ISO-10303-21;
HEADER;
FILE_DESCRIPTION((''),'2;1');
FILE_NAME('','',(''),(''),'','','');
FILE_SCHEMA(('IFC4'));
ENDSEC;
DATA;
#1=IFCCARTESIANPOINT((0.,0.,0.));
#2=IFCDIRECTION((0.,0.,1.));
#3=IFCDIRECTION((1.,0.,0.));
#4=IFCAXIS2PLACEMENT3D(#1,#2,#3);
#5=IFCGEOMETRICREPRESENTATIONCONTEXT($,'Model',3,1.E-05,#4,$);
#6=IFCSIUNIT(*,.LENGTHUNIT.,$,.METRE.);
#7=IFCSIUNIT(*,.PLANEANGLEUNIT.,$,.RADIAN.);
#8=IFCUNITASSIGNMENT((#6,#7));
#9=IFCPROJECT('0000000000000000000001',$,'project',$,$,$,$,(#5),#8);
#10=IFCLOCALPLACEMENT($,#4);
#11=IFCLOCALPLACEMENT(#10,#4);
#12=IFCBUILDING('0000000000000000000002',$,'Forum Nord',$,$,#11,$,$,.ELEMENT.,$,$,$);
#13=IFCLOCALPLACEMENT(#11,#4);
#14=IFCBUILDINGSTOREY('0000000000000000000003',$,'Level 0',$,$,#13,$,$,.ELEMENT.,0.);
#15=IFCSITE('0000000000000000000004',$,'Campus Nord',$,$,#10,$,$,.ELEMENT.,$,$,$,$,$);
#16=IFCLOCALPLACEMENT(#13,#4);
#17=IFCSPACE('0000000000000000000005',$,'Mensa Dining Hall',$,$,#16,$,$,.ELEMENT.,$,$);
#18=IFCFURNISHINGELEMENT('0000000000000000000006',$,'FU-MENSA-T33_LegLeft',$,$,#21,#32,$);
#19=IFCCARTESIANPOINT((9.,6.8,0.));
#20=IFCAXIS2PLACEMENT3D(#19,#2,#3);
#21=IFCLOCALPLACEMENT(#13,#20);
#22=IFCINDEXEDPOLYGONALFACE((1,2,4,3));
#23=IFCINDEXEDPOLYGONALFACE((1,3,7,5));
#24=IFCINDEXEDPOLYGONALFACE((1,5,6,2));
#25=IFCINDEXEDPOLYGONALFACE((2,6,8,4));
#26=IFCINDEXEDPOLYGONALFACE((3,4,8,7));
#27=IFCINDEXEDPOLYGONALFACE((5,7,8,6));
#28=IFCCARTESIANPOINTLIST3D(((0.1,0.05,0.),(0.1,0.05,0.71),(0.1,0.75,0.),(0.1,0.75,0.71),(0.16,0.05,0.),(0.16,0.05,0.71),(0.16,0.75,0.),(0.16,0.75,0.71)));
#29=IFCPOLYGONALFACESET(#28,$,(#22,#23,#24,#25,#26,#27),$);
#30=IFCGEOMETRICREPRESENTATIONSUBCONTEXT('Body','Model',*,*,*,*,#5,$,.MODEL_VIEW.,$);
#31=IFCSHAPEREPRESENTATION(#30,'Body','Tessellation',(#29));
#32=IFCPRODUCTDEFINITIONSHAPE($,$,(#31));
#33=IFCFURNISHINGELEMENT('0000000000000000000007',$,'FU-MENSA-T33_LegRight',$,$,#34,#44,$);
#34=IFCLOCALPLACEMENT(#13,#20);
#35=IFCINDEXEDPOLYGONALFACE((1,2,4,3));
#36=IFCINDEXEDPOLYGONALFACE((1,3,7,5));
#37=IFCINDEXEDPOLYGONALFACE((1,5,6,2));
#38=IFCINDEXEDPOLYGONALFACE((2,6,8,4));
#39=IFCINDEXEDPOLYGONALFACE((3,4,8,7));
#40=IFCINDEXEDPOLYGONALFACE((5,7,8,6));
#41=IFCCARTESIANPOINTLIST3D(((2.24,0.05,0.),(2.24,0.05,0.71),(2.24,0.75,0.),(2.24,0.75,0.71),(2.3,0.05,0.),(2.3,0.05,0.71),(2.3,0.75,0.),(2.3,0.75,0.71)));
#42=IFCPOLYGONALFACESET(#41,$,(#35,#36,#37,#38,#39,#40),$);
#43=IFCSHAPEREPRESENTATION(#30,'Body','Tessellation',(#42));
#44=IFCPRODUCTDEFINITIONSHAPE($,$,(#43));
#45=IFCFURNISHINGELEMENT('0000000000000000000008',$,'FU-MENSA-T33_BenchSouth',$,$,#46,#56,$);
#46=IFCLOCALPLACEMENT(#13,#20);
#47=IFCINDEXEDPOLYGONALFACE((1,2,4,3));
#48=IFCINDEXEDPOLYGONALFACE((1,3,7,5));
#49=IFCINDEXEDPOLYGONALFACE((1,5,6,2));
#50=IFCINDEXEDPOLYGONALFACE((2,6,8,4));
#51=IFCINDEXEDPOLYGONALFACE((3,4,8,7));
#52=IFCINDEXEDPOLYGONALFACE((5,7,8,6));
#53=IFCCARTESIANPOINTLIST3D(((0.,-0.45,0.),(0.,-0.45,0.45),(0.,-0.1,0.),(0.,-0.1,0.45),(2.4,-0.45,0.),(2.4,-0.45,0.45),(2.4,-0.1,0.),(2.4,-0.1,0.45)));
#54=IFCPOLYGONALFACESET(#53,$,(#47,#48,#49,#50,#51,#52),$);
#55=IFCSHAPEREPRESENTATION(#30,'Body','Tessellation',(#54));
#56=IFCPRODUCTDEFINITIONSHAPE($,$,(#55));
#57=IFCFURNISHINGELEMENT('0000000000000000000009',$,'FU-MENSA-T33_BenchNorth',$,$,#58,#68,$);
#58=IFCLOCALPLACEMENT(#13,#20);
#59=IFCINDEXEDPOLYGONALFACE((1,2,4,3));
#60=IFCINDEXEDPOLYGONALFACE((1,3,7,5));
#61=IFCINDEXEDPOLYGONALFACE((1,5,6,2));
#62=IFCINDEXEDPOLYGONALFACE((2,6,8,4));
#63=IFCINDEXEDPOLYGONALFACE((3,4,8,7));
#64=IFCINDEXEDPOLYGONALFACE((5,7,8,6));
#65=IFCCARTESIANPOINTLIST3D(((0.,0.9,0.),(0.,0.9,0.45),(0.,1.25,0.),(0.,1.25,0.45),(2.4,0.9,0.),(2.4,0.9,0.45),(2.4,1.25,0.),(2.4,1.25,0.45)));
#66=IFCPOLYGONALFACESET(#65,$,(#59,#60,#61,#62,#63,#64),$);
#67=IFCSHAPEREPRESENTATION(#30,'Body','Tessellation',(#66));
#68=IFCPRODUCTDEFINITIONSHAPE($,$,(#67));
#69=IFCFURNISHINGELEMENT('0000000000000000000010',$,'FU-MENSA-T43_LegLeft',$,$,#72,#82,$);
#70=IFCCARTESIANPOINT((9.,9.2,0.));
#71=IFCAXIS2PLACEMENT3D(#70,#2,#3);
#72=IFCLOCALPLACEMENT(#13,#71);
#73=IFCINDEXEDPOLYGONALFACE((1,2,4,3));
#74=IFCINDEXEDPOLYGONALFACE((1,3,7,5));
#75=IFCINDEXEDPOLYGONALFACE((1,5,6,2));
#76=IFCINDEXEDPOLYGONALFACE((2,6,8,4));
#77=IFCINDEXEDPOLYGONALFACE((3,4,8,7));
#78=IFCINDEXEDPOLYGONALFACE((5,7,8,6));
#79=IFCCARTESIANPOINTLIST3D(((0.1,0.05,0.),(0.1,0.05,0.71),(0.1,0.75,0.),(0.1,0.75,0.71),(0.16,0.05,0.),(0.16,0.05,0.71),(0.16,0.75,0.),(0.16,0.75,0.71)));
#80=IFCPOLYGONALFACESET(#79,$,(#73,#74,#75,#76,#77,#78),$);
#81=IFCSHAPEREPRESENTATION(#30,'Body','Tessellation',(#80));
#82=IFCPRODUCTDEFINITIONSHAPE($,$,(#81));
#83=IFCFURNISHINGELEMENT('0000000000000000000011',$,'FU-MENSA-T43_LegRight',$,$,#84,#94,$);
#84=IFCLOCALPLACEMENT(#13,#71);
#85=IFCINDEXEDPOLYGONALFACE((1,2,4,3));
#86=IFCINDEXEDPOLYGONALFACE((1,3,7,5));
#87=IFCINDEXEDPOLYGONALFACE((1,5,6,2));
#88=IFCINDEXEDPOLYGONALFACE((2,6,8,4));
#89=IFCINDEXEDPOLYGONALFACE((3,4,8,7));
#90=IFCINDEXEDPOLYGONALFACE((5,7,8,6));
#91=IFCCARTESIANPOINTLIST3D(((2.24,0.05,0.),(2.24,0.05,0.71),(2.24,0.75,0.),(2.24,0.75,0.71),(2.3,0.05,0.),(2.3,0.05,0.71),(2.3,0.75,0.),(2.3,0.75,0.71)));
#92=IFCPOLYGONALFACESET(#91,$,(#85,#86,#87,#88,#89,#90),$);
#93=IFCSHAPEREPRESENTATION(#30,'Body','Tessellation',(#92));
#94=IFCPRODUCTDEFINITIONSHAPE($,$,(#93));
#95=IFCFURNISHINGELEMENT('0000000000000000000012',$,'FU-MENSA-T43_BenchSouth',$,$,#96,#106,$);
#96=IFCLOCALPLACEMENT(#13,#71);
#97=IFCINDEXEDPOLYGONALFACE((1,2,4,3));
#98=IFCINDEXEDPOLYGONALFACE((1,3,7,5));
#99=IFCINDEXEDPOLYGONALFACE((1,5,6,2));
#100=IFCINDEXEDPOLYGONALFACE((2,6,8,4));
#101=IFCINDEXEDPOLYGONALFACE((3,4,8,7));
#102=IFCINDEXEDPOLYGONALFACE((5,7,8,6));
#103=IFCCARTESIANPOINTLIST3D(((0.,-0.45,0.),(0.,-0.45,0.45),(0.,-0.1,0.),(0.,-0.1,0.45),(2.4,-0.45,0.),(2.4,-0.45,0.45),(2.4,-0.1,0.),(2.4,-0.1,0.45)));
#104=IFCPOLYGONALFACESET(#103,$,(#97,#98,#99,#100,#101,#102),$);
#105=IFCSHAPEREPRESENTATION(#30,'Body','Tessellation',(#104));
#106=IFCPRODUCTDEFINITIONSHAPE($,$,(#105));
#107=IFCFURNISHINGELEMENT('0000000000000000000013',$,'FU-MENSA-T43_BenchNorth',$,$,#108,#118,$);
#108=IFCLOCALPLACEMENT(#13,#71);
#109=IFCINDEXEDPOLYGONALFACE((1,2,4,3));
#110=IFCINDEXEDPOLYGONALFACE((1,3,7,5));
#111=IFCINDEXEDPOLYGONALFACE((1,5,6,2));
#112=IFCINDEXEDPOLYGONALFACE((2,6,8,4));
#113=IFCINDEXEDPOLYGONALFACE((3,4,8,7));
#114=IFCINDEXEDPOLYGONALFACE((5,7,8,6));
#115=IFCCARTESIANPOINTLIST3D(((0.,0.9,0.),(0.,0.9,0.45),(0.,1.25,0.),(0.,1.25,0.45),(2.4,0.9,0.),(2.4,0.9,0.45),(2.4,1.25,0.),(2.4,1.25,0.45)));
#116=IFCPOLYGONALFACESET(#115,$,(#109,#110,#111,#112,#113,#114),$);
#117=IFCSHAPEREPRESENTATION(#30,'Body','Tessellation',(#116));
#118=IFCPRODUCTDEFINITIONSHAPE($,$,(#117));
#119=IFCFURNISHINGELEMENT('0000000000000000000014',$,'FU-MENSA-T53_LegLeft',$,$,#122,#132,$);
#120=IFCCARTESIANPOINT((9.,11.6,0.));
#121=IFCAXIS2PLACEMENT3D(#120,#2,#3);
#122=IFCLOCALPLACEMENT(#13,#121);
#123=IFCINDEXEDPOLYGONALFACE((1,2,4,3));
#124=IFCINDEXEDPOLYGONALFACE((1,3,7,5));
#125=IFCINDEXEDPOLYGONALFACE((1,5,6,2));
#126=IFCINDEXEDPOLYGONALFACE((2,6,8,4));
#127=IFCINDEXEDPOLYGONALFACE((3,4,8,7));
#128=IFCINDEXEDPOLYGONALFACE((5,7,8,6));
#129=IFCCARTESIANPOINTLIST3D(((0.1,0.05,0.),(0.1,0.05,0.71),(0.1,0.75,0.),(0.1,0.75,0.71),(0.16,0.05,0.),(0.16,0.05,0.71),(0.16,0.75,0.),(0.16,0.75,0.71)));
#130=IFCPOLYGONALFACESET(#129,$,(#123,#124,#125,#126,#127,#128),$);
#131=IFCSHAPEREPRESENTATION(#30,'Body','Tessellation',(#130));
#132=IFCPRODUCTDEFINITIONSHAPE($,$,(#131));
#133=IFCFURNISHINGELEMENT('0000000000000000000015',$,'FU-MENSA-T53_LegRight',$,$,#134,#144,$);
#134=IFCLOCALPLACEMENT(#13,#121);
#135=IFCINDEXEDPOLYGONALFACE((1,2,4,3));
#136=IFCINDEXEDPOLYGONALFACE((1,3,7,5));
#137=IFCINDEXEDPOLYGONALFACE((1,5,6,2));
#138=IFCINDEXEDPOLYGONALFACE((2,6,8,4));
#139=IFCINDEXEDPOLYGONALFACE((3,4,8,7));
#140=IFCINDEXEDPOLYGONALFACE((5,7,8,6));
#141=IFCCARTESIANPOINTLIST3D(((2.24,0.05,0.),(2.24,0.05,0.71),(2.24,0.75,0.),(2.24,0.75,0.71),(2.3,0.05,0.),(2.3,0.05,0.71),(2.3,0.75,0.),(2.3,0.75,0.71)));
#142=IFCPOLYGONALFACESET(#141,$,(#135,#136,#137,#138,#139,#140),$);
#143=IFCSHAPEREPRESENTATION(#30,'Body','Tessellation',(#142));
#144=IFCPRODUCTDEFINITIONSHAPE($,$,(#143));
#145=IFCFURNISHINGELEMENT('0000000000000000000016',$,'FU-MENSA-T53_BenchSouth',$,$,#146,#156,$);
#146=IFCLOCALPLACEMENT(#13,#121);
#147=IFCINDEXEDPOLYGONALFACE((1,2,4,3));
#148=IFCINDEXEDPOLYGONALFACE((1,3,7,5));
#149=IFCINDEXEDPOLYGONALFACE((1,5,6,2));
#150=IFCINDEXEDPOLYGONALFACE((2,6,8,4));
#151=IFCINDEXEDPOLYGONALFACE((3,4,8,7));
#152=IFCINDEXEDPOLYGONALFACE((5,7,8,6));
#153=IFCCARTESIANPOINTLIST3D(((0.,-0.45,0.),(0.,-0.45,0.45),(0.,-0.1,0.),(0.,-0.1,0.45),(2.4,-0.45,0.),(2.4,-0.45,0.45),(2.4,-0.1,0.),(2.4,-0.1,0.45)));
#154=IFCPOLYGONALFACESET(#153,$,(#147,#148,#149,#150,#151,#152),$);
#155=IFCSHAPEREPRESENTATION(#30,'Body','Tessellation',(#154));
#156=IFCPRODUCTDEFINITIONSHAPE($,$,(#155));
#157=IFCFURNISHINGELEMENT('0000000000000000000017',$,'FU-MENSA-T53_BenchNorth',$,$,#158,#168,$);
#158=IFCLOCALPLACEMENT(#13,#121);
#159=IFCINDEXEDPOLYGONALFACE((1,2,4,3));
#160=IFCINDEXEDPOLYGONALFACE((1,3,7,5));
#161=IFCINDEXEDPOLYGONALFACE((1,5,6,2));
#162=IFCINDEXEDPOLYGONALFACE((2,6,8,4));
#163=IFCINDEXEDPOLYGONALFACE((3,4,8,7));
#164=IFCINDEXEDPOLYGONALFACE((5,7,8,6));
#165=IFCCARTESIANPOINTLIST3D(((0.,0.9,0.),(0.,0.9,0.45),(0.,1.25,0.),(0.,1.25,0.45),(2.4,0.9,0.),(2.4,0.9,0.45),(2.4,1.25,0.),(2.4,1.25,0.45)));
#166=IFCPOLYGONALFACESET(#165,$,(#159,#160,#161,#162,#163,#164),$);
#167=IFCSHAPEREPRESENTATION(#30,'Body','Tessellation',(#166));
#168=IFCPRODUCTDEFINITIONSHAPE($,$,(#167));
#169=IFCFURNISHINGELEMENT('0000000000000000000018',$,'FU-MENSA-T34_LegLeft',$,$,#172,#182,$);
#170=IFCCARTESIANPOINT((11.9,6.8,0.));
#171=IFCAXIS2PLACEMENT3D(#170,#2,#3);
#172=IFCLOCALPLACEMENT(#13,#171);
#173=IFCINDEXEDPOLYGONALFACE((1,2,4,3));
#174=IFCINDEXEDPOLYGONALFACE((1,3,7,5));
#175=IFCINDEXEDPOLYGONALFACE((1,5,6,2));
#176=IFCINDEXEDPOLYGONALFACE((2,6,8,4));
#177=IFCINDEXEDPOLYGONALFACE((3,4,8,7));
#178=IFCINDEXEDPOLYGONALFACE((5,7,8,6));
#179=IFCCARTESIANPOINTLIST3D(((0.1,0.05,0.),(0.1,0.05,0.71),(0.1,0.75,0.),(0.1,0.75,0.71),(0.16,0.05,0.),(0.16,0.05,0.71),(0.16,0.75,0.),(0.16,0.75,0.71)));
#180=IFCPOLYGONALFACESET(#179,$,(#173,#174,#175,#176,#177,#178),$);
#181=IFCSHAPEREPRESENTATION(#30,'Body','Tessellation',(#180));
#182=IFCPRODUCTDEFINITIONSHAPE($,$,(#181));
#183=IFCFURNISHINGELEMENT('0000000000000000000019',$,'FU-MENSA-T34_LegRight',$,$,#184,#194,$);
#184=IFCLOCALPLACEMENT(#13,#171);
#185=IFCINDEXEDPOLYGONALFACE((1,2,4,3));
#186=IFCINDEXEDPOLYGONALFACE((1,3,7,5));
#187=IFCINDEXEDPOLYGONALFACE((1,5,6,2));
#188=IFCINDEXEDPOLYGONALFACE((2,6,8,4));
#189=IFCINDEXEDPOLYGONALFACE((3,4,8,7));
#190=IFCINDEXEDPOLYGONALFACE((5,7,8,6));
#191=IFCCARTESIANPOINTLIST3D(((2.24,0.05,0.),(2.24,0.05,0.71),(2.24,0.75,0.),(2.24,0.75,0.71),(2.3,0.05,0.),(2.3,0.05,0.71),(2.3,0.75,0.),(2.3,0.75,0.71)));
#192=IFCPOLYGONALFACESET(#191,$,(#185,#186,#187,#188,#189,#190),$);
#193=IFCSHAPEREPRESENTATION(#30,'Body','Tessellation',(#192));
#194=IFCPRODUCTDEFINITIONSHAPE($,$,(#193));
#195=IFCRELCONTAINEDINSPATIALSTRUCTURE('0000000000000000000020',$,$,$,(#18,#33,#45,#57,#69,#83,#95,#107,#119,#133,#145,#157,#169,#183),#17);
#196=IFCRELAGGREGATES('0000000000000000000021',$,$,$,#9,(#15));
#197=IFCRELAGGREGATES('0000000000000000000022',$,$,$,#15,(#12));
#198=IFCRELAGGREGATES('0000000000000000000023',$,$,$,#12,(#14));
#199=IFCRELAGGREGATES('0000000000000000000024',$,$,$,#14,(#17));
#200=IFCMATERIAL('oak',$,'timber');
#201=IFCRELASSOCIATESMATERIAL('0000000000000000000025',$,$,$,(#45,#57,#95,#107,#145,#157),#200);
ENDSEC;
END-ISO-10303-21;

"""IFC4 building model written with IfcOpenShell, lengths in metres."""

from ifc_helpers import new_model, si_unit, frame, frame_2d, origin_with_axes, place, context, subcontext, project, spatial, rectangle, extrude, material, element, save


model = new_model("IFC4")

# Units and contexts
model_context = context("Model", 3, precision=1e-05, world=origin_with_axes())
body_context = subcontext(model_context, "Body", "Model", "MODEL_VIEW")
ifc_project = project(units=[si_unit("LENGTHUNIT", "METRE"), si_unit("PLANEANGLEUNIT", "RADIAN")], contexts=[model_context])

# Site, building, storey
site_placement = place(None, origin_with_axes())
site = spatial("IfcSite", under=ifc_project, at=site_placement, Name="Campus Nord", CompositionType="ELEMENT")
building_placement = place(site_placement, origin_with_axes())
building = spatial("IfcBuilding", under=site, at=building_placement, Name="Forum Nord", CompositionType="ELEMENT")
storey_placement = place(building_placement, origin_with_axes())
storey = spatial("IfcBuildingStorey", under=building, at=storey_placement, Name="Level 0", CompositionType="ELEMENT", Elevation=0.0)

# Shared definitions
space_placement = place(storey_placement, origin_with_axes())
space = spatial("IfcSpace", under=storey, at=space_placement, Name="Mensa Dining Hall", CompositionType="ELEMENT")

# Furnishing elements
ifc_material_1 = material(Name="oak", Category="timber")
furnishing_1_placement = place(storey_placement, frame((9.0, 6.8, 0.0), z_axis=(0.0, 0.0, 1.0), x_axis=(1.0, 0.0, 0.0)))
element("IfcFurnishingElement", 1, at=furnishing_1_placement, inside=space, Name="FU-MENSA-T33_LegLeft", context=body_context, shape_type="SweptSolid", body=[
    extrude(rectangle(XDim=0.06, YDim=0.7, at=frame_2d((0.13, 0.4), x_axis=(1.0, 0.0))), origin_with_axes(), (0.0, 0.0, 1.0), 0.71),
])
furnishing_2_placement = place(storey_placement, frame((9.0, 6.8, 0.0), z_axis=(0.0, 0.0, 1.0), x_axis=(1.0, 0.0, 0.0)))
element("IfcFurnishingElement", 2, at=furnishing_2_placement, inside=space, Name="FU-MENSA-T33_LegRight", context=body_context, shape_type="SweptSolid", body=[
    extrude(rectangle(XDim=0.06, YDim=0.7, at=frame_2d((2.27, 0.4), x_axis=(1.0, 0.0))), origin_with_axes(), (0.0, 0.0, 1.0), 0.71),
])
furnishing_3_placement = place(storey_placement, frame((9.0, 6.8, 0.0), z_axis=(0.0, 0.0, 1.0), x_axis=(1.0, 0.0, 0.0)))
element("IfcFurnishingElement", 3, at=furnishing_3_placement, inside=space, material=ifc_material_1, Name="FU-MENSA-T33_BenchSouth", context=body_context, shape_type="SweptSolid", body=[
    extrude(rectangle(XDim=2.4, YDim=0.35, at=frame_2d((1.2, -0.275), x_axis=(1.0, 0.0))), origin_with_axes(), (0.0, 0.0, 1.0), 0.45),
])
furnishing_4_placement = place(storey_placement, frame((9.0, 6.8, 0.0), z_axis=(0.0, 0.0, 1.0), x_axis=(1.0, 0.0, 0.0)))
element("IfcFurnishingElement", 4, at=furnishing_4_placement, inside=space, material=ifc_material_1, Name="FU-MENSA-T33_BenchNorth", context=body_context, shape_type="SweptSolid", body=[
    extrude(rectangle(XDim=2.4, YDim=0.35, at=frame_2d((1.2, 1.075), x_axis=(1.0, 0.0))), origin_with_axes(), (0.0, 0.0, 1.0), 0.45),
])
furnishing_5_placement = place(storey_placement, frame((9.0, 9.2, 0.0), z_axis=(0.0, 0.0, 1.0), x_axis=(1.0, 0.0, 0.0)))
element("IfcFurnishingElement", 5, at=furnishing_5_placement, inside=space, Name="FU-MENSA-T43_LegLeft", context=body_context, shape_type="SweptSolid", body=[
    extrude(rectangle(XDim=0.06, YDim=0.7, at=frame_2d((0.13, 0.4), x_axis=(1.0, 0.0))), origin_with_axes(), (0.0, 0.0, 1.0), 0.71),
])
furnishing_6_placement = place(storey_placement, frame((9.0, 9.2, 0.0), z_axis=(0.0, 0.0, 1.0), x_axis=(1.0, 0.0, 0.0)))
element("IfcFurnishingElement", 6, at=furnishing_6_placement, inside=space, Name="FU-MENSA-T43_LegRight", context=body_context, shape_type="SweptSolid", body=[
    extrude(rectangle(XDim=0.06, YDim=0.7, at=frame_2d((2.27, 0.4), x_axis=(1.0, 0.0))), origin_with_axes(), (0.0, 0.0, 1.0), 0.71),
])
furnishing_7_placement = place(storey_placement, frame((9.0, 9.2, 0.0), z_axis=(0.0, 0.0, 1.0), x_axis=(1.0, 0.0, 0.0)))
element("IfcFurnishingElement", 7, at=furnishing_7_placement, inside=space, material=ifc_material_1, Name="FU-MENSA-T43_BenchSouth", context=body_context, shape_type="SweptSolid", body=[
    extrude(rectangle(XDim=2.4, YDim=0.35, at=frame_2d((1.2, -0.275), x_axis=(1.0, 0.0))), origin_with_axes(), (0.0, 0.0, 1.0), 0.45),
])
furnishing_8_placement = place(storey_placement, frame((9.0, 9.2, 0.0), z_axis=(0.0, 0.0, 1.0), x_axis=(1.0, 0.0, 0.0)))
element("IfcFurnishingElement", 8, at=furnishing_8_placement, inside=space, material=ifc_material_1, Name="FU-MENSA-T43_BenchNorth", context=body_context, shape_type="SweptSolid", body=[
    extrude(rectangle(XDim=2.4, YDim=0.35, at=frame_2d((1.2, 1.075), x_axis=(1.0, 0.0))), origin_with_axes(), (0.0, 0.0, 1.0), 0.45),
])
furnishing_9_placement = place(storey_placement, frame((9.0, 11.6, 0.0), z_axis=(0.0, 0.0, 1.0), x_axis=(1.0, 0.0, 0.0)))
element("IfcFurnishingElement", 9, at=furnishing_9_placement, inside=space, Name="FU-MENSA-T53_LegLeft", context=body_context, shape_type="SweptSolid", body=[
    extrude(rectangle(XDim=0.06, YDim=0.7, at=frame_2d((0.13, 0.4), x_axis=(1.0, 0.0))), origin_with_axes(), (0.0, 0.0, 1.0), 0.71),
])
furnishing_10_placement = place(storey_placement, frame((9.0, 11.6, 0.0), z_axis=(0.0, 0.0, 1.0), x_axis=(1.0, 0.0, 0.0)))
element("IfcFurnishingElement", 10, at=furnishing_10_placement, inside=space, Name="FU-MENSA-T53_LegRight", context=body_context, shape_type="SweptSolid", body=[
    extrude(rectangle(XDim=0.06, YDim=0.7, at=frame_2d((2.27, 0.4), x_axis=(1.0, 0.0))), origin_with_axes(), (0.0, 0.0, 1.0), 0.71),
])
furnishing_11_placement = place(storey_placement, frame((9.0, 11.6, 0.0), z_axis=(0.0, 0.0, 1.0), x_axis=(1.0, 0.0, 0.0)))
element("IfcFurnishingElement", 11, at=furnishing_11_placement, inside=space, material=ifc_material_1, Name="FU-MENSA-T53_BenchSouth", context=body_context, shape_type="SweptSolid", body=[
    extrude(rectangle(XDim=2.4, YDim=0.35, at=frame_2d((1.2, -0.275), x_axis=(1.0, 0.0))), origin_with_axes(), (0.0, 0.0, 1.0), 0.45),
])
furnishing_12_placement = place(storey_placement, frame((9.0, 11.6, 0.0), z_axis=(0.0, 0.0, 1.0), x_axis=(1.0, 0.0, 0.0)))
element("IfcFurnishingElement", 12, at=furnishing_12_placement, inside=space, material=ifc_material_1, Name="FU-MENSA-T53_BenchNorth", context=body_context, shape_type="SweptSolid", body=[
    extrude(rectangle(XDim=2.4, YDim=0.35, at=frame_2d((1.2, 1.075), x_axis=(1.0, 0.0))), origin_with_axes(), (0.0, 0.0, 1.0), 0.45),
])
furnishing_13_placement = place(storey_placement, frame((11.9, 6.8, 0.0), z_axis=(0.0, 0.0, 1.0), x_axis=(1.0, 0.0, 0.0)))
element("IfcFurnishingElement", 13, at=furnishing_13_placement, inside=space, Name="FU-MENSA-T34_LegLeft", context=body_context, shape_type="SweptSolid", body=[
    extrude(rectangle(XDim=0.06, YDim=0.7, at=frame_2d((0.13, 0.4), x_axis=(1.0, 0.0))), origin_with_axes(), (0.0, 0.0, 1.0), 0.71),
])
furnishing_14_placement = place(storey_placement, frame((11.9, 6.8, 0.0), z_axis=(0.0, 0.0, 1.0), x_axis=(1.0, 0.0, 0.0)))
element("IfcFurnishingElement", 14, at=furnishing_14_placement, inside=space, Name="FU-MENSA-T34_LegRight", context=body_context, shape_type="SweptSolid", body=[
    extrude(rectangle(XDim=0.06, YDim=0.7, at=frame_2d((2.27, 0.4), x_axis=(1.0, 0.0))), origin_with_axes(), (0.0, 0.0, 1.0), 0.71),
])

save(model, "model.ifc")
